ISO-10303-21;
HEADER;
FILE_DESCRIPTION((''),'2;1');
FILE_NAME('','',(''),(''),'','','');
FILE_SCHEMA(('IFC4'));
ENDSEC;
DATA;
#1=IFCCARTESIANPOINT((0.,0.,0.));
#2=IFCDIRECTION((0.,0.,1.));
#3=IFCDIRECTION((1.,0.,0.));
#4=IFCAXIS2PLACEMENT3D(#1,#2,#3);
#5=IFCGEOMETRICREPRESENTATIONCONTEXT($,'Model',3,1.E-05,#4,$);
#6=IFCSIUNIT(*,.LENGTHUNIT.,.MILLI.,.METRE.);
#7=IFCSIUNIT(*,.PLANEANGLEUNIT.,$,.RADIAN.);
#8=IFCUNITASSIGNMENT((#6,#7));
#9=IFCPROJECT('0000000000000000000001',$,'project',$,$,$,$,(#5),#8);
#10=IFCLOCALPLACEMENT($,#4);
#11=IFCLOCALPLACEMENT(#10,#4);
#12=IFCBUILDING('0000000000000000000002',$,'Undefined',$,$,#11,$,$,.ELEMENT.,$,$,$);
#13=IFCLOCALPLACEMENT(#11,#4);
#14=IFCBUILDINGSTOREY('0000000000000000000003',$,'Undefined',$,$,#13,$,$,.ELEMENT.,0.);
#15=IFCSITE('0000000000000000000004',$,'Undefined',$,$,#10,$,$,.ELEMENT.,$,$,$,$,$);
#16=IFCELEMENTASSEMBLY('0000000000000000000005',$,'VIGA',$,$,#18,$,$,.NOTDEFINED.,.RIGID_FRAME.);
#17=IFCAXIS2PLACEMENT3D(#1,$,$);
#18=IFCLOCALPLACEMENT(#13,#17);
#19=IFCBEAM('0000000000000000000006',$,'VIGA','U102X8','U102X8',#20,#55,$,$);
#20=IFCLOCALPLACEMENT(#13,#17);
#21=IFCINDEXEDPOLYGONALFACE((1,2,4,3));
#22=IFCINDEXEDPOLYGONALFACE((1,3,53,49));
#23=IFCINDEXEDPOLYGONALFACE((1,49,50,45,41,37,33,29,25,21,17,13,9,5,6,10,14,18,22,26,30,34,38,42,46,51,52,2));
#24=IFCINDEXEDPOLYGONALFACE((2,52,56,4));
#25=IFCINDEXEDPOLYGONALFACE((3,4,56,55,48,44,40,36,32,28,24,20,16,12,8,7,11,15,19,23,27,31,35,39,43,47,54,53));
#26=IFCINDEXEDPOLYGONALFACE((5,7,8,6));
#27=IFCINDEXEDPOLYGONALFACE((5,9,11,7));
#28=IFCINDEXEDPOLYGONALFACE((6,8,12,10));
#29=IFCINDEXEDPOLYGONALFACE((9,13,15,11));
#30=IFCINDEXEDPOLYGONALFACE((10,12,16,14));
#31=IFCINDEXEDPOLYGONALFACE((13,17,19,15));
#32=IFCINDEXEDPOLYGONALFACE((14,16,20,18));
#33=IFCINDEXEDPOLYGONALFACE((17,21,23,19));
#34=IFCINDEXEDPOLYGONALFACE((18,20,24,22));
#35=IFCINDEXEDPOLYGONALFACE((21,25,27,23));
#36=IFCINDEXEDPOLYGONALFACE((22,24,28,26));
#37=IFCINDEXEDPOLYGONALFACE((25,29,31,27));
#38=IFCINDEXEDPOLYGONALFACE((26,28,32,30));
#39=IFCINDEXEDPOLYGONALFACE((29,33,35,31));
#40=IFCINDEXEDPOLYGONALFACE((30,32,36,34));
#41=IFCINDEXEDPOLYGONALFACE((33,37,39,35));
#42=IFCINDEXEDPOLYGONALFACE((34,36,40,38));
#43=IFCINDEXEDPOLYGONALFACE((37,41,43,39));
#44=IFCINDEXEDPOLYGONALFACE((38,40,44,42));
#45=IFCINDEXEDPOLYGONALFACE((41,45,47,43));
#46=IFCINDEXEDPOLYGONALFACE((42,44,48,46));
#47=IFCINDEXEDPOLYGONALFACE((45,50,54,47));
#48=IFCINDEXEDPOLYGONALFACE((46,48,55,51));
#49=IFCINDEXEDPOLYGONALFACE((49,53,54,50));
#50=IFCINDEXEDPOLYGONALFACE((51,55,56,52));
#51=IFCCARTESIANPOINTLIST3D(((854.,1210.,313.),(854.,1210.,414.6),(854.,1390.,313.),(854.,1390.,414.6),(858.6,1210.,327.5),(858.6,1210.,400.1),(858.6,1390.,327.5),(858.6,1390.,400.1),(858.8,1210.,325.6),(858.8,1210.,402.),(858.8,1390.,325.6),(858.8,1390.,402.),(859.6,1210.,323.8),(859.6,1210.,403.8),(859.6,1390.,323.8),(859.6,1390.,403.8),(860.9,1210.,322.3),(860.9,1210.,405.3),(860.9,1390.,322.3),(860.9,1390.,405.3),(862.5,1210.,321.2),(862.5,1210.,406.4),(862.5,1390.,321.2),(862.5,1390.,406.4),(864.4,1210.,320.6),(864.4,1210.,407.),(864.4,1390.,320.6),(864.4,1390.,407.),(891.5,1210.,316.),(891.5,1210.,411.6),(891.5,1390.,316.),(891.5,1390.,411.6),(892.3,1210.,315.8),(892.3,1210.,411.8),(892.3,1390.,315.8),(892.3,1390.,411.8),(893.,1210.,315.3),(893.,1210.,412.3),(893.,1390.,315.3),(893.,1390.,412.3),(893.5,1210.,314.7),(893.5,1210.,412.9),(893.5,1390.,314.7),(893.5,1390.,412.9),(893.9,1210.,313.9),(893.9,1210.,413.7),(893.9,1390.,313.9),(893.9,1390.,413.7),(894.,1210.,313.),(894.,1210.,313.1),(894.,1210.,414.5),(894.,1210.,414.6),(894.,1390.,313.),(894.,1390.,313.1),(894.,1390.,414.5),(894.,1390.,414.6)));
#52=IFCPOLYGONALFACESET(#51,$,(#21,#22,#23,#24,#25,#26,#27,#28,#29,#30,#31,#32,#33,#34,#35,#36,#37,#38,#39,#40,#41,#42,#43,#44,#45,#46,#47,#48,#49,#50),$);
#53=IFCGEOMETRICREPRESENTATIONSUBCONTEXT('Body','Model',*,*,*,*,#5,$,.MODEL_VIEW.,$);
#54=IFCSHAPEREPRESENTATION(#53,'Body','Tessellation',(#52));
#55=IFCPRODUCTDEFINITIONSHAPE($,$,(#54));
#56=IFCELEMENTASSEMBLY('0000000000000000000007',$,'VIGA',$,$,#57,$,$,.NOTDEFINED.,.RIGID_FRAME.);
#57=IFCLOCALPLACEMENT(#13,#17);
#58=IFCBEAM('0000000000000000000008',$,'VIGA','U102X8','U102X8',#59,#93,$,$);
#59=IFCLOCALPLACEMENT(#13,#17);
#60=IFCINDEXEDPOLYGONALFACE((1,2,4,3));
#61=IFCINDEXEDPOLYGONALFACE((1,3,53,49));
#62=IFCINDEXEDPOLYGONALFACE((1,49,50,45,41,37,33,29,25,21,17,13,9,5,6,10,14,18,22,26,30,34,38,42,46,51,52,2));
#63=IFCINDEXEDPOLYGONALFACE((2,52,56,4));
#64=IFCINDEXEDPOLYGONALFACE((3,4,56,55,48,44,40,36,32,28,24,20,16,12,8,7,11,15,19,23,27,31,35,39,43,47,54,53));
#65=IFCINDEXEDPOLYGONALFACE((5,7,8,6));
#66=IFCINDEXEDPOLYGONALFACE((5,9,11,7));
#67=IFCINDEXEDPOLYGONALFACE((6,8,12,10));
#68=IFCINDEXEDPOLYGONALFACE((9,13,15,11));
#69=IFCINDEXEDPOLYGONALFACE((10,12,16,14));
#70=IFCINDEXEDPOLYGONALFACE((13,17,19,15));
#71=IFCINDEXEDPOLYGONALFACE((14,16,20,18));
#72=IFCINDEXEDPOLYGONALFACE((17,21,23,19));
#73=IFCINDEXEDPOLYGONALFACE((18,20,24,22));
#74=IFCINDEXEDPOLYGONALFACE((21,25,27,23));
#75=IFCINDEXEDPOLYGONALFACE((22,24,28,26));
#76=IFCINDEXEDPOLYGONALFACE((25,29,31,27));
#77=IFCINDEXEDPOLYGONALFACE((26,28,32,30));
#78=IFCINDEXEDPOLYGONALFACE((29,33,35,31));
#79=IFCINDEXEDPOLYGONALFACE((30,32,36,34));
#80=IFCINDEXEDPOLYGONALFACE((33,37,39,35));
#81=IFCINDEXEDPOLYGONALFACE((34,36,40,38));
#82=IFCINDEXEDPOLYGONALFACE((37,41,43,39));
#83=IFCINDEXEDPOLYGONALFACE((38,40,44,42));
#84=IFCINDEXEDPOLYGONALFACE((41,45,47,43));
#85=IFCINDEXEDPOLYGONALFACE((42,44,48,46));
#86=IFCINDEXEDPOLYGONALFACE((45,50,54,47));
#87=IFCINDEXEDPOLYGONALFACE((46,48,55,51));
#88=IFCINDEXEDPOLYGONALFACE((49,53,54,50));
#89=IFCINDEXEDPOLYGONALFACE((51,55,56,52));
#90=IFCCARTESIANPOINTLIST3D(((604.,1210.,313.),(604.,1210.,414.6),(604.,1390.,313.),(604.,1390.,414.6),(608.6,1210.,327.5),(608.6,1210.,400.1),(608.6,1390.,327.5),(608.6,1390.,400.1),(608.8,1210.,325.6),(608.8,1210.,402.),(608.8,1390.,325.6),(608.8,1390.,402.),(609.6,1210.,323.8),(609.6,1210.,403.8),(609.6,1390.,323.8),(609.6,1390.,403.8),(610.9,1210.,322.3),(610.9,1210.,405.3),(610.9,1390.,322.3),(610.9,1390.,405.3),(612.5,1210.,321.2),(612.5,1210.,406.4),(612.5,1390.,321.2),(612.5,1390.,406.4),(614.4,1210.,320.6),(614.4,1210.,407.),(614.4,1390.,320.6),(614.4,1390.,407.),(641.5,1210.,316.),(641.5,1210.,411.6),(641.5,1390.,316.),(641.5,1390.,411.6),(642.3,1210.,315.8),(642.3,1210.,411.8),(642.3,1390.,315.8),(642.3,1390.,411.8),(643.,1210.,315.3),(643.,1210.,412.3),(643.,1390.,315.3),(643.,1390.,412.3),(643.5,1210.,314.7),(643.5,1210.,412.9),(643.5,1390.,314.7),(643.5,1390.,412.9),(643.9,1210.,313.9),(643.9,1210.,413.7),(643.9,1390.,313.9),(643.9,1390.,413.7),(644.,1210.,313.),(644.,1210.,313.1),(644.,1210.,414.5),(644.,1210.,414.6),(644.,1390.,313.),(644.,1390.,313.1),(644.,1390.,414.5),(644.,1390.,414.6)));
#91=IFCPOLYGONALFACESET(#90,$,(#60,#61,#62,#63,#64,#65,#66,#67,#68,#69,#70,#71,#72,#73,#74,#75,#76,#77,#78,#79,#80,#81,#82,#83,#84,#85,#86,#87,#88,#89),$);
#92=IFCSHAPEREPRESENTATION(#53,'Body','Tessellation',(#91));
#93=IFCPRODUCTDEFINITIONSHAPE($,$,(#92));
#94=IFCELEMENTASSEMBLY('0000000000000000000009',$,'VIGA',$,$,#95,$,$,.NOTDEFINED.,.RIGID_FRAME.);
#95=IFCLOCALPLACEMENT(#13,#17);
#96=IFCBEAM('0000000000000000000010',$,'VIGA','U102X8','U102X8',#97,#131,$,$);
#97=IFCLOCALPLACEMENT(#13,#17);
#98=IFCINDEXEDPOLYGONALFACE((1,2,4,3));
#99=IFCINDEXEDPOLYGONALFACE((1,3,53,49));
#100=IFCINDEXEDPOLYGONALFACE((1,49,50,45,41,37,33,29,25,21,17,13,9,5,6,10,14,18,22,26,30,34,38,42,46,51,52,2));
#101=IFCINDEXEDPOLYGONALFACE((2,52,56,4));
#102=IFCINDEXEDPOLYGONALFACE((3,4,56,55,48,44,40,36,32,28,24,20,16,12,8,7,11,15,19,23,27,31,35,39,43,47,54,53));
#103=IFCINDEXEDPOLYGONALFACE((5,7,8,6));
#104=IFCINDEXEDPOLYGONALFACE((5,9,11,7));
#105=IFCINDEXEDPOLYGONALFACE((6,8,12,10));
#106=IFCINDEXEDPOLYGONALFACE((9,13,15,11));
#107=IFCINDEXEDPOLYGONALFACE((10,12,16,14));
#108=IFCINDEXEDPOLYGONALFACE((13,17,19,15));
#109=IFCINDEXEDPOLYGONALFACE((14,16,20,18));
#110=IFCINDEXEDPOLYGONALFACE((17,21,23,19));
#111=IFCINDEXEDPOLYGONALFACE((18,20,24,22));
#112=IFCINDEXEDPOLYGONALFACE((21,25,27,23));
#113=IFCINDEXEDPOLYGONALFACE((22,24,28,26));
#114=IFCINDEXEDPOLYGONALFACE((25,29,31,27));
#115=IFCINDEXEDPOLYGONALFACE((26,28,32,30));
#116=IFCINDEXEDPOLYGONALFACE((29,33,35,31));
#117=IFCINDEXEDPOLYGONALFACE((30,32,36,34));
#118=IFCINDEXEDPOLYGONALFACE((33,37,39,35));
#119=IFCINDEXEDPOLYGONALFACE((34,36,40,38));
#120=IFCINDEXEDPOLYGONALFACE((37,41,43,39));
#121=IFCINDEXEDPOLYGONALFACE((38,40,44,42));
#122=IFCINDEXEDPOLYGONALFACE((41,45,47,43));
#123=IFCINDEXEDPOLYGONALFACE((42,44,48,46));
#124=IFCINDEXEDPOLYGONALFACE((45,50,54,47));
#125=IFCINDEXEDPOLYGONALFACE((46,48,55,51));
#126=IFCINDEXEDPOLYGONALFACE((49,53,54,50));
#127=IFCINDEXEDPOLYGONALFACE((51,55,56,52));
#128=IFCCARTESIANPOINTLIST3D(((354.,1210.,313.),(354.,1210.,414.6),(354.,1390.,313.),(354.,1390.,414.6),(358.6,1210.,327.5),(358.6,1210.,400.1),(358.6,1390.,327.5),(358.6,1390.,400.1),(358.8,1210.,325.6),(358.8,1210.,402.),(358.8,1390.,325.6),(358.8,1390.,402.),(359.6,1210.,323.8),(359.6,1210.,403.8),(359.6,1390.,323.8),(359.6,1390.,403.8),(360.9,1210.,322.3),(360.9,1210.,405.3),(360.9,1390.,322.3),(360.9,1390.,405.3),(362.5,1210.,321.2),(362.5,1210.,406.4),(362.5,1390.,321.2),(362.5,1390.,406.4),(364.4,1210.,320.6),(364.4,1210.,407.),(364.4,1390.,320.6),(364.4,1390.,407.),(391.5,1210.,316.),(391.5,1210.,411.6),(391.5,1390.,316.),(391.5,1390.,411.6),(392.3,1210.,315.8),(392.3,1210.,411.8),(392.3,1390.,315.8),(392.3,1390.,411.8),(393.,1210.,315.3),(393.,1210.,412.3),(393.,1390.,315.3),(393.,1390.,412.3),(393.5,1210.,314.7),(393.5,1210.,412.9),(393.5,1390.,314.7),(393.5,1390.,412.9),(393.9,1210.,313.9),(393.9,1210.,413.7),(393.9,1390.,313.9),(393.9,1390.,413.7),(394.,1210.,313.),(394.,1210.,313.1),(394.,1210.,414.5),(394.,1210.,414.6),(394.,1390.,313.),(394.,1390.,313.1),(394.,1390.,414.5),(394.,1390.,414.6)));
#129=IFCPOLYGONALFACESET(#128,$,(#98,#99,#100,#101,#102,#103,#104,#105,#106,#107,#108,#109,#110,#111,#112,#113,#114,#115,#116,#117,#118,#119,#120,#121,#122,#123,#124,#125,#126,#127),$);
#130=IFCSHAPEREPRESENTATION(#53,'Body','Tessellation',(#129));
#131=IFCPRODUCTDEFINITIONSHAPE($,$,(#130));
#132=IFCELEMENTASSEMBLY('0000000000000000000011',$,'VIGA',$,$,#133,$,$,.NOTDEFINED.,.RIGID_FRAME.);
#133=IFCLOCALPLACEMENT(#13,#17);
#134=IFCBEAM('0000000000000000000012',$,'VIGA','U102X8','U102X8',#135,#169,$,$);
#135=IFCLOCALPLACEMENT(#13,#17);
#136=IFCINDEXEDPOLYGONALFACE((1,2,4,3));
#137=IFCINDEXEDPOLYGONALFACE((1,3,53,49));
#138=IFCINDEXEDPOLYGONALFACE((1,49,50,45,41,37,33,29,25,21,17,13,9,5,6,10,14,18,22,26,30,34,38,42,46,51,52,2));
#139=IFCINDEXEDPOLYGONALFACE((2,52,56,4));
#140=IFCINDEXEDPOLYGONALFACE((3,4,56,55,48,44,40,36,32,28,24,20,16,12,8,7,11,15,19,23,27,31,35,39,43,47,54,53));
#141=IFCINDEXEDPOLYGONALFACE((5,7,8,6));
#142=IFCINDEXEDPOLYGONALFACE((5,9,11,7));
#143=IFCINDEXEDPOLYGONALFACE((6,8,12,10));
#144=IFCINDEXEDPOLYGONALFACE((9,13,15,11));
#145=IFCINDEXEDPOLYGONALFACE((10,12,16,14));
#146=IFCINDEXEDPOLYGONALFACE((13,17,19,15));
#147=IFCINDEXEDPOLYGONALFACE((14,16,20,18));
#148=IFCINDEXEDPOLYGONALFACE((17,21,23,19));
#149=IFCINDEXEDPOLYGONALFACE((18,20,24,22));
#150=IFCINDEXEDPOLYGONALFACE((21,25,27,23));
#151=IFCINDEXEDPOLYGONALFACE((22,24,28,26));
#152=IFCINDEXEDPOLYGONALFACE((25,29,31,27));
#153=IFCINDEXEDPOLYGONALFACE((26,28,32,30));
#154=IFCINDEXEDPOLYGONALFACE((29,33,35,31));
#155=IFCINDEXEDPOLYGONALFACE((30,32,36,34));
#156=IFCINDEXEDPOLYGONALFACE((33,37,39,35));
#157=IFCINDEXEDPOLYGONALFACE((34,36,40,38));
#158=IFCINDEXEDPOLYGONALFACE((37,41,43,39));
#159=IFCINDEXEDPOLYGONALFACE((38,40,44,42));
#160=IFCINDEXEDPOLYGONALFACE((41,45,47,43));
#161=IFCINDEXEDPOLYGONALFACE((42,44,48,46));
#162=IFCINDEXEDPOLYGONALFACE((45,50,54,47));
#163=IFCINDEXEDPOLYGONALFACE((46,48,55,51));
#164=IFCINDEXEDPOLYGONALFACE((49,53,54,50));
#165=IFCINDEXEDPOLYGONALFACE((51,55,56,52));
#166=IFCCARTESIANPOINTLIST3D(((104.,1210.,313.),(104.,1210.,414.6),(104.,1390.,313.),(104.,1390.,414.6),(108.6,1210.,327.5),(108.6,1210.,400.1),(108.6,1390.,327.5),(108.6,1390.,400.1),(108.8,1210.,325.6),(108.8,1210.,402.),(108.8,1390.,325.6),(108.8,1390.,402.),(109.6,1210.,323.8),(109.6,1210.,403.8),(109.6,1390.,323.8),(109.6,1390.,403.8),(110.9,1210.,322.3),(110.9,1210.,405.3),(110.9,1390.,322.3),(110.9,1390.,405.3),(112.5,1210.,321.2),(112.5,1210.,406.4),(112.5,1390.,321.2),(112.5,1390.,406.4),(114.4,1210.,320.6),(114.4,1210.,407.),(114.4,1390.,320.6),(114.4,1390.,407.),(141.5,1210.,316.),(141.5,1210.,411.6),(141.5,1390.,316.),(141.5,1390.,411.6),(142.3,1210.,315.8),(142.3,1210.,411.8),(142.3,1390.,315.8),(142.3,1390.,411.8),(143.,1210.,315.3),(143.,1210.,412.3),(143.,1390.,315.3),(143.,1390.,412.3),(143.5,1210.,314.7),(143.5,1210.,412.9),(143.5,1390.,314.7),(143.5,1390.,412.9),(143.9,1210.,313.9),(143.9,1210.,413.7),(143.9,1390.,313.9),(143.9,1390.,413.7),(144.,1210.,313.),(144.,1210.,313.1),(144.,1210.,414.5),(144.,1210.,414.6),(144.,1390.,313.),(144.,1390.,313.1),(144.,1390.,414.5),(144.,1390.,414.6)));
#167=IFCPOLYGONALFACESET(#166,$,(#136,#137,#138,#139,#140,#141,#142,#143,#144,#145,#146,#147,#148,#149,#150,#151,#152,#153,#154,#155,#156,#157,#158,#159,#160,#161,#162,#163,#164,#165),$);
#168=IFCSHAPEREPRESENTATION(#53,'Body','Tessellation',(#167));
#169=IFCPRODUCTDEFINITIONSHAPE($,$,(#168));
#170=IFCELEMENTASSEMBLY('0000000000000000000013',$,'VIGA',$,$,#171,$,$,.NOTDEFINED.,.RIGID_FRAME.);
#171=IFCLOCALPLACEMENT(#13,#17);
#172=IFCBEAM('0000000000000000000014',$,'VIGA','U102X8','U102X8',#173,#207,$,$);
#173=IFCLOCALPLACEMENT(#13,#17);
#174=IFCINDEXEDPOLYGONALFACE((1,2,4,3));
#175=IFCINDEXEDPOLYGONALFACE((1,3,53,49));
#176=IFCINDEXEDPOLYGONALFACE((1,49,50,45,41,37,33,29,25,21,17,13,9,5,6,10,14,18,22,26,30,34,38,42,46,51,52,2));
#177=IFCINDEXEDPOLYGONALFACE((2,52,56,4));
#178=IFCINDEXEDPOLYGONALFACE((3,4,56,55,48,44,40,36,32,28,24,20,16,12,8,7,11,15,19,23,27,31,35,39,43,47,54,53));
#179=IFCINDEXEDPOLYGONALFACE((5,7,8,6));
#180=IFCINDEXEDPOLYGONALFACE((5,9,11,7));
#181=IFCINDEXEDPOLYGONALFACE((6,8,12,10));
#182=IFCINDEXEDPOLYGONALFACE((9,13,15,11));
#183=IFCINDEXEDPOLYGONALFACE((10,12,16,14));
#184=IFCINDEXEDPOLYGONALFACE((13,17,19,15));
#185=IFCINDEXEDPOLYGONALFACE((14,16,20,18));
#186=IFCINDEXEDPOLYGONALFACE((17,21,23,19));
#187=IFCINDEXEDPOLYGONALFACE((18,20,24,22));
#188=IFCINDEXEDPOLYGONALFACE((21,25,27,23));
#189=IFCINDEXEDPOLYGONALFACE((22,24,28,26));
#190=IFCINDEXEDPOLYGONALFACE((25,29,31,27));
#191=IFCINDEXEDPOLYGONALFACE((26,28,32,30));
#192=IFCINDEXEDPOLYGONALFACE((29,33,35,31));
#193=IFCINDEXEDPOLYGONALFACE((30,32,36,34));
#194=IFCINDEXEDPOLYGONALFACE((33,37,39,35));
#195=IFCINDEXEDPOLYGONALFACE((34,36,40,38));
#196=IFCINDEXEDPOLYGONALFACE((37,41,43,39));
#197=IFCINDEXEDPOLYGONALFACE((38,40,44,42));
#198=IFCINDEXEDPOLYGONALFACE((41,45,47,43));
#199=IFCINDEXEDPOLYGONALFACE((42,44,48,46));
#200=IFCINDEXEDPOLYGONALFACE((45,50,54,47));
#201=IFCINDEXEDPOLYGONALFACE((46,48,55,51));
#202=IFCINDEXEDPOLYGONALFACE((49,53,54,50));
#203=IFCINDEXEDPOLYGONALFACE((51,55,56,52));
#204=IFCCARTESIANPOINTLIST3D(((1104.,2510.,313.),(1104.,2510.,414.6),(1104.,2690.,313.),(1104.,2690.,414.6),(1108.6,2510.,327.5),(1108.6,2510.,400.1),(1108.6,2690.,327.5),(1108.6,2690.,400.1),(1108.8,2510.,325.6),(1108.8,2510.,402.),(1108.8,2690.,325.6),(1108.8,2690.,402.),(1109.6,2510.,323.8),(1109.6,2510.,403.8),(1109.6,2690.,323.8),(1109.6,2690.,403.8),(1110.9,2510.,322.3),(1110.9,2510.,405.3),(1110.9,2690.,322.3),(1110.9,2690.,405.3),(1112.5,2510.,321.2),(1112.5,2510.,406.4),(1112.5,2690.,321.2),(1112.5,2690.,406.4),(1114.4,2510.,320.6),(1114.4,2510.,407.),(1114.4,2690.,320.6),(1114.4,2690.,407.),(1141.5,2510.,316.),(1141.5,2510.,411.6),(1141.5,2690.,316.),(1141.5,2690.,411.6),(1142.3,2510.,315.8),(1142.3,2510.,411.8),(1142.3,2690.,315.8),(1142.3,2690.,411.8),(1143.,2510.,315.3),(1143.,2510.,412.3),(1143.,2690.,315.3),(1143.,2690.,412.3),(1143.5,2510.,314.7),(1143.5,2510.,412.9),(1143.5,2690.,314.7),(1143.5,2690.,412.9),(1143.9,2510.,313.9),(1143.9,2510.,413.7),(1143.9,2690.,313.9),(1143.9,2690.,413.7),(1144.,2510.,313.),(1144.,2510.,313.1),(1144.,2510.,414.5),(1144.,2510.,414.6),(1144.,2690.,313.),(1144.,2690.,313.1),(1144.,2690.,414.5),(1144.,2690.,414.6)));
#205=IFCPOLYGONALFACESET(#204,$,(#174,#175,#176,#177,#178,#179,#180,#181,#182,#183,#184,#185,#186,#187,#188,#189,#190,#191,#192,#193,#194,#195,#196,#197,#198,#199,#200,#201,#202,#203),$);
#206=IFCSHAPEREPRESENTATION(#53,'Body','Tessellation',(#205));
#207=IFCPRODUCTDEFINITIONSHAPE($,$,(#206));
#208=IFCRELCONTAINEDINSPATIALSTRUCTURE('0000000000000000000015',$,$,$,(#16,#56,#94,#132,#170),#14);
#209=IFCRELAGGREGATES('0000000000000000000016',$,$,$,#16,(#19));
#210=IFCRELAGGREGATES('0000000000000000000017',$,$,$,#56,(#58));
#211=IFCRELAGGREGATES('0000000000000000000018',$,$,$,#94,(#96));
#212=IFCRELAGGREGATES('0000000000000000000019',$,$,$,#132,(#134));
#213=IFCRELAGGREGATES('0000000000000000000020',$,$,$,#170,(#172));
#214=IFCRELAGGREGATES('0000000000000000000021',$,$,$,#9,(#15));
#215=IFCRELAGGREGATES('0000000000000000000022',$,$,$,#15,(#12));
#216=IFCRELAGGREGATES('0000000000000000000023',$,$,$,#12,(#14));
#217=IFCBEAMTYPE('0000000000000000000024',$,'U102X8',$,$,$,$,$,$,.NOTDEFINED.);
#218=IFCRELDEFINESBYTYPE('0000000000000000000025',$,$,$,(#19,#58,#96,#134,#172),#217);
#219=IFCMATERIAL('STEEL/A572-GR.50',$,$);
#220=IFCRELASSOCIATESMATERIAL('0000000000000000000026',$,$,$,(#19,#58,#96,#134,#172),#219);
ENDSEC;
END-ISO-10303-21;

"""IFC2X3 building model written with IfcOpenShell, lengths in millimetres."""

from ifc_helpers import new_model, si_unit, frame, origin_with_axes, origin_2d_with_axis, place, context, subcontext, project, spatial, u_section, extrude, material, type_object, element, aggregate, save


model = new_model("IFC2X3")

# Units and contexts
model_context = context("Model", 3, precision=1e-05, world=origin_with_axes())
body_context = subcontext(model_context, "Body", "Model", "MODEL_VIEW")
ifc_project = project(units=[si_unit("LENGTHUNIT", "METRE", prefix="MILLI"), si_unit("PLANEANGLEUNIT", "RADIAN")], contexts=[model_context])

# Site, building, storey
site_placement = place(None, origin_with_axes())
site = spatial("IfcSite", under=ifc_project, at=site_placement, Name="Undefined", CompositionType="ELEMENT")
building_placement = place(site_placement, origin_with_axes())
building = spatial("IfcBuilding", under=site, at=building_placement, Name="Undefined", CompositionType="ELEMENT")
storey_placement = place(building_placement, origin_with_axes())
storey = spatial("IfcBuildingStorey", under=building, at=storey_placement, Name="Undefined", CompositionType="ELEMENT", Elevation=0.0)

# Element assemblies, beams
ifc_material_1 = material(Name="STEEL/A572-GR.50")
beam_type_1 = type_object("IfcBeamType", Name="U102X8", PredefinedType="NOTDEFINED")
assembly_1_placement = place(storey_placement, origin_with_axes())
assembly_1 = element("IfcElementAssembly", 1, at=assembly_1_placement, inside=storey, Name="VIGA", AssemblyPlace="NOTDEFINED", PredefinedType="RIGID_FRAME")
beam_1_placement = place(assembly_1_placement, frame((874.0, 1210.0, 363.8), z_axis=(0.0, 0.0, 1.0), x_axis=(0.0, 1.0, 0.0)))
beam_1 = element("IfcBeam", 2, at=beam_1_placement, type_object=beam_type_1, material=ifc_material_1, Name="VIGA", Description="U102X8", ObjectType="U102X8", context=body_context, shape_type="SweptSolid", body=[
    extrude(u_section(Depth=101.6, FlangeWidth=40.0, WebThickness=4.6, FlangeThickness=6.0, FilletRadius=7.0, EdgeRadius=3.0, FlangeSlope=0.16839, at=origin_2d_with_axis()), frame((180.0, 0.0, 0.0), z_axis=(-1.0, 0.0, 0.0), x_axis=(0.0, -1.0, 0.0)), (0.0, 0.0, 1.0), 180.0),
])
aggregate(assembly_1, [beam_1])
assembly_2_placement = place(storey_placement, origin_with_axes())
assembly_2 = element("IfcElementAssembly", 3, at=assembly_2_placement, inside=storey, Name="VIGA", AssemblyPlace="NOTDEFINED", PredefinedType="RIGID_FRAME")
beam_2_placement = place(assembly_2_placement, frame((624.0, 1210.0, 363.8), z_axis=(0.0, 0.0, 1.0), x_axis=(0.0, 1.0, 0.0)))
beam_2 = element("IfcBeam", 4, at=beam_2_placement, type_object=beam_type_1, material=ifc_material_1, Name="VIGA", Description="U102X8", ObjectType="U102X8", context=body_context, shape_type="SweptSolid", body=[
    extrude(u_section(Depth=101.6, FlangeWidth=40.0, WebThickness=4.6, FlangeThickness=6.0, FilletRadius=7.0, EdgeRadius=3.0, FlangeSlope=0.16839, at=origin_2d_with_axis()), frame((180.0, 0.0, 0.0), z_axis=(-1.0, 0.0, 0.0), x_axis=(0.0, -1.0, 0.0)), (0.0, 0.0, 1.0), 180.0),
])
aggregate(assembly_2, [beam_2])
assembly_3_placement = place(storey_placement, origin_with_axes())
assembly_3 = element("IfcElementAssembly", 5, at=assembly_3_placement, inside=storey, Name="VIGA", AssemblyPlace="NOTDEFINED", PredefinedType="RIGID_FRAME")
beam_3_placement = place(assembly_3_placement, frame((374.0, 1210.0, 363.8), z_axis=(0.0, 0.0, 1.0), x_axis=(0.0, 1.0, 0.0)))
beam_3 = element("IfcBeam", 6, at=beam_3_placement, type_object=beam_type_1, material=ifc_material_1, Name="VIGA", Description="U102X8", ObjectType="U102X8", context=body_context, shape_type="SweptSolid", body=[
    extrude(u_section(Depth=101.6, FlangeWidth=40.0, WebThickness=4.6, FlangeThickness=6.0, FilletRadius=7.0, EdgeRadius=3.0, FlangeSlope=0.16839, at=origin_2d_with_axis()), frame((180.0, 0.0, 0.0), z_axis=(-1.0, 0.0, 0.0), x_axis=(0.0, -1.0, 0.0)), (0.0, 0.0, 1.0), 180.0),
])
aggregate(assembly_3, [beam_3])
assembly_4_placement = place(storey_placement, origin_with_axes())
assembly_4 = element("IfcElementAssembly", 7, at=assembly_4_placement, inside=storey, Name="VIGA", AssemblyPlace="NOTDEFINED", PredefinedType="RIGID_FRAME")
beam_4_placement = place(assembly_4_placement, frame((124.0, 1210.0, 363.8), z_axis=(0.0, 0.0, 1.0), x_axis=(0.0, 1.0, 0.0)))
beam_4 = element("IfcBeam", 8, at=beam_4_placement, type_object=beam_type_1, material=ifc_material_1, Name="VIGA", Description="U102X8", ObjectType="U102X8", context=body_context, shape_type="SweptSolid", body=[
    extrude(u_section(Depth=101.6, FlangeWidth=40.0, WebThickness=4.6, FlangeThickness=6.0, FilletRadius=7.0, EdgeRadius=3.0, FlangeSlope=0.16839, at=origin_2d_with_axis()), frame((180.0, 0.0, 0.0), z_axis=(-1.0, 0.0, 0.0), x_axis=(0.0, -1.0, 0.0)), (0.0, 0.0, 1.0), 180.0),
])
aggregate(assembly_4, [beam_4])
assembly_5_placement = place(storey_placement, origin_with_axes())
assembly_5 = element("IfcElementAssembly", 9, at=assembly_5_placement, inside=storey, Name="VIGA", AssemblyPlace="NOTDEFINED", PredefinedType="RIGID_FRAME")
beam_5_placement = place(assembly_5_placement, frame((1124.0, 2510.0, 363.8), z_axis=(0.0, 0.0, 1.0), x_axis=(0.0, 1.0, 0.0)))
beam_5 = element("IfcBeam", 10, at=beam_5_placement, type_object=beam_type_1, material=ifc_material_1, Name="VIGA", Description="U102X8", ObjectType="U102X8", context=body_context, shape_type="SweptSolid", body=[
    extrude(u_section(Depth=101.6, FlangeWidth=40.0, WebThickness=4.6, FlangeThickness=6.0, FilletRadius=7.0, EdgeRadius=3.0, FlangeSlope=0.16839, at=origin_2d_with_axis()), frame((180.0, 0.0, 0.0), z_axis=(-1.0, 0.0, 0.0), x_axis=(0.0, -1.0, 0.0)), (0.0, 0.0, 1.0), 180.0),
])
aggregate(assembly_5, [beam_5])

save(model, "model.ifc")
